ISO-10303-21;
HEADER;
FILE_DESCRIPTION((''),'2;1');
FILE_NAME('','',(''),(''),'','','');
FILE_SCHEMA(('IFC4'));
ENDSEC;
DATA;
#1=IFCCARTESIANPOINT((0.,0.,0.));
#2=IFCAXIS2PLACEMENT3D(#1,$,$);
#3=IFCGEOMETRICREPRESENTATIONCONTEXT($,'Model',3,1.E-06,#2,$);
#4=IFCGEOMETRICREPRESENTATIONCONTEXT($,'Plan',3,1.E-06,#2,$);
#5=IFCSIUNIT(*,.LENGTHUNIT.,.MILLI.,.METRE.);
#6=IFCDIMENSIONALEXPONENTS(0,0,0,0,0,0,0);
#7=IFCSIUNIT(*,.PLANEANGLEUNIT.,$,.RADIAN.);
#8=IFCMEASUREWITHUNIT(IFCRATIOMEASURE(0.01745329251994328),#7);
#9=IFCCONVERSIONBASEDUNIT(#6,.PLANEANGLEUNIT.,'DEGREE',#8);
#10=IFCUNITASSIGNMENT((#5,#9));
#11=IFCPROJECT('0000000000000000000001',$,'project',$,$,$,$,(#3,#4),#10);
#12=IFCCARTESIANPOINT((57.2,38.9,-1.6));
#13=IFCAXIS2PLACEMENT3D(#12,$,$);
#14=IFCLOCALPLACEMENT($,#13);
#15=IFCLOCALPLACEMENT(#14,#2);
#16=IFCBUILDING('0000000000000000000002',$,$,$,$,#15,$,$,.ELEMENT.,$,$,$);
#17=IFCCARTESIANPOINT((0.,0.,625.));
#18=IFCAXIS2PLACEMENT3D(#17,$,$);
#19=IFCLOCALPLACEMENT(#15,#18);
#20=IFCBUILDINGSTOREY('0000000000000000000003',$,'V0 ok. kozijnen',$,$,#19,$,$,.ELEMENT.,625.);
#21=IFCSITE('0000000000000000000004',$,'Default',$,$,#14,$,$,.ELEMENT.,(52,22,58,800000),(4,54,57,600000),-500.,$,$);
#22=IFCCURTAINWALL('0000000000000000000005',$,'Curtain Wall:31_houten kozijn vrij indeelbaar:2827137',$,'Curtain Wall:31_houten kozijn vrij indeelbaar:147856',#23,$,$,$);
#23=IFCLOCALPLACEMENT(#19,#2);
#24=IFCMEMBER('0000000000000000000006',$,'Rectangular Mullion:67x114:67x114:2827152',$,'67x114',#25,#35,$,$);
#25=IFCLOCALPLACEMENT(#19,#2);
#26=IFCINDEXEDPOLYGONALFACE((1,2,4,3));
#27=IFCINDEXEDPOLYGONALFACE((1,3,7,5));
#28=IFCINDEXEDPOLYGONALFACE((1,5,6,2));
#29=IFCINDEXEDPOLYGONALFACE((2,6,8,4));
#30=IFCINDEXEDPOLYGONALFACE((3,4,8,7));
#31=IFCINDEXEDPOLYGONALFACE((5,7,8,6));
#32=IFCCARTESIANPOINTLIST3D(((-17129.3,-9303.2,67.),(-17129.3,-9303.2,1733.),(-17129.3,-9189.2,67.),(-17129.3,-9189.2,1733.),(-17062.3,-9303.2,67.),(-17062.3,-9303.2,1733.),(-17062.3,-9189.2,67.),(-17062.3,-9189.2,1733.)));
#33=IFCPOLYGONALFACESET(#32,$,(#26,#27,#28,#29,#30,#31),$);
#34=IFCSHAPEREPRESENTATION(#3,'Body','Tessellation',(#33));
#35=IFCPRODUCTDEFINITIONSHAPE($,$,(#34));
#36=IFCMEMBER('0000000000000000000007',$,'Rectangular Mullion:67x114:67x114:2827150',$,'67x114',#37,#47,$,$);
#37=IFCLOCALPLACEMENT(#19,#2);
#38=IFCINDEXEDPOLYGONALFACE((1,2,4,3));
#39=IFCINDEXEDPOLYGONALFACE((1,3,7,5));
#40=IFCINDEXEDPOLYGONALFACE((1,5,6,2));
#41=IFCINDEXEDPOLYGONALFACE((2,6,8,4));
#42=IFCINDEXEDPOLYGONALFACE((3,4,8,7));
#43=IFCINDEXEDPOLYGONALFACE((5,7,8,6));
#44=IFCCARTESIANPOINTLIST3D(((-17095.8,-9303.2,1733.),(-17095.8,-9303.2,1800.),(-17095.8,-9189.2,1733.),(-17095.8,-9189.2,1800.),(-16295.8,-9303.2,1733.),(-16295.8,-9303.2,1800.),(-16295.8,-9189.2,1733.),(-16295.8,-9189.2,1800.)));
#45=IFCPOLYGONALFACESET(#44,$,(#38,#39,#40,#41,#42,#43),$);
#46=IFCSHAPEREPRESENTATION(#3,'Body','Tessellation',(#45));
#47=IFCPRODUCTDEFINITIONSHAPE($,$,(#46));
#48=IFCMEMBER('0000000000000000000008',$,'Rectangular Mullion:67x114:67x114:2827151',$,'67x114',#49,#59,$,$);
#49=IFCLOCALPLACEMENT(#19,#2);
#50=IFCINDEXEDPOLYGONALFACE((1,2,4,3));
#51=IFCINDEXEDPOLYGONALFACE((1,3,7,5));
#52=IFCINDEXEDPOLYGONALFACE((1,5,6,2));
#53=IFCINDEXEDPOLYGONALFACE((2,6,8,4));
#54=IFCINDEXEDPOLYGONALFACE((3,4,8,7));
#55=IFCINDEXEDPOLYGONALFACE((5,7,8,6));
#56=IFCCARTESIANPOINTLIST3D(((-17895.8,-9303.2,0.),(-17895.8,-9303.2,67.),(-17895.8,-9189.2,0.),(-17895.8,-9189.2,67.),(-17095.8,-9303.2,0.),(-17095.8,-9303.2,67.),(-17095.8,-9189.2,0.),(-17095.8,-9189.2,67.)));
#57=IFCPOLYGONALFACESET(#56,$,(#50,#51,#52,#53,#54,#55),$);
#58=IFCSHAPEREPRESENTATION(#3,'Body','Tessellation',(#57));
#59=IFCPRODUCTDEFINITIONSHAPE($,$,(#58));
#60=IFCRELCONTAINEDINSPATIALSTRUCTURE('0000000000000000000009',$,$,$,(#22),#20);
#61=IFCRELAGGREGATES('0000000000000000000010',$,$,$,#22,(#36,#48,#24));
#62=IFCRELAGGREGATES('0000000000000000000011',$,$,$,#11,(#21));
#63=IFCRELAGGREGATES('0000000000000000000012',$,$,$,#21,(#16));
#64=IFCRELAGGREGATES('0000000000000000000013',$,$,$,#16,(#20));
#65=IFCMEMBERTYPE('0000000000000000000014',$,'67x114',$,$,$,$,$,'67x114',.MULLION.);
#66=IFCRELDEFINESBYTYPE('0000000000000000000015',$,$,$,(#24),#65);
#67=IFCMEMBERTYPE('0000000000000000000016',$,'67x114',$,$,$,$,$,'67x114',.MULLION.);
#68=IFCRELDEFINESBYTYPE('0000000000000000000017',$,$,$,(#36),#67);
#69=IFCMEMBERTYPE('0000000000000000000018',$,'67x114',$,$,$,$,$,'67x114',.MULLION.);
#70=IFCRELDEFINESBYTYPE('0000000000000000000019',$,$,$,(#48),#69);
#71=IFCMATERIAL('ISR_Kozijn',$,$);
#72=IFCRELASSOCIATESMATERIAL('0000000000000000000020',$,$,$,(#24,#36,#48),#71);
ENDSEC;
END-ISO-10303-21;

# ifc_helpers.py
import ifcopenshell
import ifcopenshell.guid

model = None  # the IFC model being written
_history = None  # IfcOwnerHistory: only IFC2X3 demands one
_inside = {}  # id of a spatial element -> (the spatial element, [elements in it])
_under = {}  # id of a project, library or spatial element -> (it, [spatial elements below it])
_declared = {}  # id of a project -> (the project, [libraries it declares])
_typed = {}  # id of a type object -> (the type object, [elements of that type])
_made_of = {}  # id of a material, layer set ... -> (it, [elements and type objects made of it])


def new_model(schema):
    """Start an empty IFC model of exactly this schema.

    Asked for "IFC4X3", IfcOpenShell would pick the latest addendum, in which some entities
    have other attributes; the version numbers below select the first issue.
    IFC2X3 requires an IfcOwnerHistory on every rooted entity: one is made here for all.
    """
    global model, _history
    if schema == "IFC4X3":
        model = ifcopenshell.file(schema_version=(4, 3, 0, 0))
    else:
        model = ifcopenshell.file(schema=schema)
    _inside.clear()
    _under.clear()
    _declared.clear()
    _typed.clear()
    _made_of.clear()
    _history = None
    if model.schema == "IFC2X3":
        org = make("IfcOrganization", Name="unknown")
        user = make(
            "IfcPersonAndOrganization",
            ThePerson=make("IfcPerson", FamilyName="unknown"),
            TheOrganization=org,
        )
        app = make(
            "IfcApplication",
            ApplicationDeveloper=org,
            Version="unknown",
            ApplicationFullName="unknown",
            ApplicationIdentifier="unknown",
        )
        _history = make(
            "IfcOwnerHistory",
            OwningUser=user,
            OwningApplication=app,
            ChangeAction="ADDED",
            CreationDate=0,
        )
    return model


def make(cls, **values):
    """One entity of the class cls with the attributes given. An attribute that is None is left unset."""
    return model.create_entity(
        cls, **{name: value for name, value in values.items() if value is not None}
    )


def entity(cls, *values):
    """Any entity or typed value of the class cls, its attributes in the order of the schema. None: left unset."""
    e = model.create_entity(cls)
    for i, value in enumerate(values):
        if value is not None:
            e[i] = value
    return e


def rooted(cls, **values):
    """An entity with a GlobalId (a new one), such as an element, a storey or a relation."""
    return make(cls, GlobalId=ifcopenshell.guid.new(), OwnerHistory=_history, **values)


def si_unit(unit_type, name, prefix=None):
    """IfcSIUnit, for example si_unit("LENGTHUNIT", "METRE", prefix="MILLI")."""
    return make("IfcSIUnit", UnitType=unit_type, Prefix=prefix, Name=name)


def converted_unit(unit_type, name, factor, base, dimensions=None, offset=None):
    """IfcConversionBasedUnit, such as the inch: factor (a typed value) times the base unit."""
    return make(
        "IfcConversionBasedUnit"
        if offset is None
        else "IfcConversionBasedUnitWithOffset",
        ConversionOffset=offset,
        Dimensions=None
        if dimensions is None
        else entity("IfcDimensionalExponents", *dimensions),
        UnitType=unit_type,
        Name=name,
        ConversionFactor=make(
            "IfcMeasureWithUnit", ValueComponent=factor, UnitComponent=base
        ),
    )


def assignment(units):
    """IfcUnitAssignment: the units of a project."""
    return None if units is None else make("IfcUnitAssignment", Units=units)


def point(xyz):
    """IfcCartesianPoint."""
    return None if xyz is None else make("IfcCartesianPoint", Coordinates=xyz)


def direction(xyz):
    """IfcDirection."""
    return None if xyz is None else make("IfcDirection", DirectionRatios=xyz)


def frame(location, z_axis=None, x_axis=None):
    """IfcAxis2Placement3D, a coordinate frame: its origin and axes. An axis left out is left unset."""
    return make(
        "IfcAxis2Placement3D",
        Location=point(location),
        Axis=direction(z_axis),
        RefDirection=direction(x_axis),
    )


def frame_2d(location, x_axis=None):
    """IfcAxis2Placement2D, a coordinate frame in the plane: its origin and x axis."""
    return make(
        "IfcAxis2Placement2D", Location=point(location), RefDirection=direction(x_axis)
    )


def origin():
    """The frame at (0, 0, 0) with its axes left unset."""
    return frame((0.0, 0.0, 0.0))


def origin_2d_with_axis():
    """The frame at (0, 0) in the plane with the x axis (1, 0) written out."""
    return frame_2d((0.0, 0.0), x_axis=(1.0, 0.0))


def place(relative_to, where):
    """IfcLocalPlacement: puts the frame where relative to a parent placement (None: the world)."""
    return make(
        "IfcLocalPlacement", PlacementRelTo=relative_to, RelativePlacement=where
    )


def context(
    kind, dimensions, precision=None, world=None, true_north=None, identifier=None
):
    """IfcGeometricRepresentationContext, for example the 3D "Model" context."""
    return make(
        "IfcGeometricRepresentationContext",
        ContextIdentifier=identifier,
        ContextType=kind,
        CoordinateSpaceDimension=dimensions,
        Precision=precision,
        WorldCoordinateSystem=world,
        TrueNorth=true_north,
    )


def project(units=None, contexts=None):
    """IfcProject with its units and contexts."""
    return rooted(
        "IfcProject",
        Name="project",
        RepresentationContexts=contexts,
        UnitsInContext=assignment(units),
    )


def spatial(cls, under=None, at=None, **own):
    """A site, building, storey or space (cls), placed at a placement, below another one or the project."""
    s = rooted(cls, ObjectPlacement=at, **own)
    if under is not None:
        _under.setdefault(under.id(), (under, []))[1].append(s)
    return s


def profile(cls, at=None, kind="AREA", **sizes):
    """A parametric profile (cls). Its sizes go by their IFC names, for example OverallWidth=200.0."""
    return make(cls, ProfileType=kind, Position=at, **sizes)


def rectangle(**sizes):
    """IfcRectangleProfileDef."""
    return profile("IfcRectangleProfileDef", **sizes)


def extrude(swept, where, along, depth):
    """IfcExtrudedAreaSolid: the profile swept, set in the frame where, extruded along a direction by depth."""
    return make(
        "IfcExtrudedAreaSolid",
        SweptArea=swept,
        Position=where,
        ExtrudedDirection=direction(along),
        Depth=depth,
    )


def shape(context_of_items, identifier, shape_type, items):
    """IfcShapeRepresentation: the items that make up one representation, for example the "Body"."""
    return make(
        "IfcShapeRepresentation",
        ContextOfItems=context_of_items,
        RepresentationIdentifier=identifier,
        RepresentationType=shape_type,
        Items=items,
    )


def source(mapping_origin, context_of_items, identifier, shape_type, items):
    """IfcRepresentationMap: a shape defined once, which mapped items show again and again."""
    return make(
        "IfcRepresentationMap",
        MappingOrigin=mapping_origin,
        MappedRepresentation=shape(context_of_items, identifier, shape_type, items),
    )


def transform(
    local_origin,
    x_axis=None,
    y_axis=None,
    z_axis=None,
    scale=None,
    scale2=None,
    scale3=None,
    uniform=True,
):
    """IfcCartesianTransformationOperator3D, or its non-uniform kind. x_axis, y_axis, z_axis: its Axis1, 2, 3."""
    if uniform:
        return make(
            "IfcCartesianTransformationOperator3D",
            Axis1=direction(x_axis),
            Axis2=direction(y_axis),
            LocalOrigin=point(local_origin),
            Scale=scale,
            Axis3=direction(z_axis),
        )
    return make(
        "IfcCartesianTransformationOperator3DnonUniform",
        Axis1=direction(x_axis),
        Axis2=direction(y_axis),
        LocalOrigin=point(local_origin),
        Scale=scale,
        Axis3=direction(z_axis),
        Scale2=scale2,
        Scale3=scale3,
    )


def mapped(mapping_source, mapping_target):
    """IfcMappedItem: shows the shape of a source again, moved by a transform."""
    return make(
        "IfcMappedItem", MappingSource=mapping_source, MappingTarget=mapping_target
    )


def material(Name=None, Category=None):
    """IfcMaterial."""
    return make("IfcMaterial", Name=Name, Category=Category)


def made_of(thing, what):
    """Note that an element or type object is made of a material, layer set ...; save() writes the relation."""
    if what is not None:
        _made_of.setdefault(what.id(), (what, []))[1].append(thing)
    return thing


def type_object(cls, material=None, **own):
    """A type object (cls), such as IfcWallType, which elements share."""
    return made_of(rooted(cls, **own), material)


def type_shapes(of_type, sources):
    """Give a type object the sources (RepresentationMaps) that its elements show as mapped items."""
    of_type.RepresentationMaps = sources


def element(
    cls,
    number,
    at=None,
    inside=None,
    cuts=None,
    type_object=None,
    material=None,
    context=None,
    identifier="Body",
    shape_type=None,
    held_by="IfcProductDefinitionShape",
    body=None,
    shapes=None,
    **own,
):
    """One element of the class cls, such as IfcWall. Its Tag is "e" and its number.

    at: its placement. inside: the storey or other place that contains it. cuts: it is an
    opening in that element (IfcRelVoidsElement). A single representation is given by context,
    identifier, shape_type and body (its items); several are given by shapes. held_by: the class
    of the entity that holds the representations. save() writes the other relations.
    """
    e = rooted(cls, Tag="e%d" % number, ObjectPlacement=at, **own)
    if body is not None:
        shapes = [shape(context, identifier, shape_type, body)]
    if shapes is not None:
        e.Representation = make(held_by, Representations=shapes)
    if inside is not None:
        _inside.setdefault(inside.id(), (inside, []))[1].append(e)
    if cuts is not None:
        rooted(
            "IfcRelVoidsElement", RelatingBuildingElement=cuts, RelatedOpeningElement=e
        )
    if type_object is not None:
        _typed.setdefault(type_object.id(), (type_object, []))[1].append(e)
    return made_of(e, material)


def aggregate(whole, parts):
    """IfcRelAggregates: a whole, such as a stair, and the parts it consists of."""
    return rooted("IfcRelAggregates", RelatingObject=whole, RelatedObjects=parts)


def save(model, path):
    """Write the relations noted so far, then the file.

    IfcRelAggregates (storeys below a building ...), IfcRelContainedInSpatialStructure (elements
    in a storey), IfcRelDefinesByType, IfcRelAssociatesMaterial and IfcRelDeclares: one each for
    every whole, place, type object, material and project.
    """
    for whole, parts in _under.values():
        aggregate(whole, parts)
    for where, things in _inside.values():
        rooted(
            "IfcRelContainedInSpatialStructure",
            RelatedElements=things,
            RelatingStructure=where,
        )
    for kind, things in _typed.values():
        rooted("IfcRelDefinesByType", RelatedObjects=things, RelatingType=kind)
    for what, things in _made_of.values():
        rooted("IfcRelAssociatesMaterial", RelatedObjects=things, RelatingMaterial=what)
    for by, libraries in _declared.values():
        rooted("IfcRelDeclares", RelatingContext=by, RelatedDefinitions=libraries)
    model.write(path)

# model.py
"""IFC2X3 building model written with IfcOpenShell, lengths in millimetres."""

from ifc_helpers import new_model, entity, si_unit, converted_unit, frame, origin, origin_2d_with_axis, place, context, project, spatial, rectangle, extrude, source, transform, mapped, material, type_object, type_shapes, element, aggregate, save


model = new_model("IFC2X3")

# Units and contexts
model_context = context("Model", 3, precision=1e-06, world=origin())
plan_context = context("Plan", 3, precision=1e-06, world=origin())
ifc_project = project(units=[si_unit("LENGTHUNIT", "METRE", prefix="MILLI"), converted_unit("PLANEANGLEUNIT", "DEGREE", entity("IfcRatioMeasure", 0.01745329251994328), si_unit("PLANEANGLEUNIT", "RADIAN"), dimensions=[0, 0, 0, 0, 0, 0, 0])], contexts=[model_context, plan_context])

# Site, building, storey
site_placement = place(None, frame((57.2, 38.9, -1.6)))
site = spatial("IfcSite", under=ifc_project, at=site_placement, Name="Default", CompositionType="ELEMENT", RefLatitude=(52, 22, 58, 800000), RefLongitude=(4, 54, 57, 600000), RefElevation=-500.0)
building_placement = place(site_placement, origin())
building = spatial("IfcBuilding", under=site, at=building_placement, CompositionType="ELEMENT")
storey_placement = place(building_placement, frame((0.0, 0.0, 625.0)))
storey = spatial("IfcBuildingStorey", under=building, at=storey_placement, Name="V0 ok. kozijnen", CompositionType="ELEMENT", Elevation=625.0)

# Curtain wall, members
ifc_material_1 = material(Name="ISR_Kozijn")
placement = place(building_placement, frame((0.0, 0.0, 2425.0)))
curtain_wall_1_placement = place(storey_placement, origin())
curtain_wall_1 = element("IfcCurtainWall", 1, at=curtain_wall_1_placement, inside=storey, Name="Curtain Wall:31_houten kozijn vrij indeelbaar:2827137", ObjectType="Curtain Wall:31_houten kozijn vrij indeelbaar:147856")
member_type_1 = type_object("IfcMemberType", Name="67x114", ElementType="67x114", PredefinedType="MULLION")
shared_shape_1 = source(origin(), model_context, "Body", "SweptSolid", [
    extrude(rectangle(XDim=67.0, YDim=114.0, at=origin_2d_with_axis()), frame((0.0, -57.0, -1666.0), z_axis=(0.0, 0.0, 1.0), x_axis=(-1.0, 0.0, 0.0)), (0.0, 0.0, 1.0), 1666.0),
])
type_shapes(member_type_1, [shared_shape_1])
member_1_placement = place(storey_placement, frame((-17095.8, -9189.2, 67.0), z_axis=(0.0, 0.0, -1.0), x_axis=(-1.0, 0.0, 0.0)))
member_1 = element("IfcMember", 2, at=member_1_placement, type_object=member_type_1, material=ifc_material_1, Name="Rectangular Mullion:67x114:67x114:2827152", ObjectType="67x114", context=model_context, shape_type="MappedRepresentation", body=[
    mapped(shared_shape_1, transform((0.0, 0.0, 0.0), scale=1.0)),
])
member_type_2 = type_object("IfcMemberType", Name="67x114", ElementType="67x114", PredefinedType="MULLION")
shared_shape_2 = source(origin(), model_context, "Body", "SweptSolid", [
    extrude(rectangle(XDim=67.0, YDim=114.0, at=origin_2d_with_axis()), frame((-33.5, -57.0, -800.0), z_axis=(0.0, 0.0, 1.0), x_axis=(-1.0, 0.0, 0.0)), (0.0, 0.0, 1.0), 800.0),
])
type_shapes(member_type_2, [shared_shape_2])
member_2_placement = place(placement, frame((-17095.8, -9189.2, 0.0), z_axis=(-1.0, 0.0, 0.0), x_axis=(0.0, 0.0, 1.0)))
member_2 = element("IfcMember", 3, at=member_2_placement, type_object=member_type_2, material=ifc_material_1, Name="Rectangular Mullion:67x114:67x114:2827150", ObjectType="67x114", context=model_context, shape_type="MappedRepresentation", body=[
    mapped(shared_shape_2, transform((0.0, 0.0, 0.0), scale=1.0)),
])
member_type_3 = type_object("IfcMemberType", Name="67x114", ElementType="67x114", PredefinedType="MULLION")
shared_shape_3 = source(origin(), model_context, "Body", "SweptSolid", [
    extrude(rectangle(XDim=67.0, YDim=114.0, at=origin_2d_with_axis()), frame((-33.5, -57.0, -800.0), z_axis=(0.0, 0.0, 1.0), x_axis=(-1.0, 0.0, 0.0)), (0.0, 0.0, 1.0), 800.0),
])
type_shapes(member_type_3, [shared_shape_3])
member_3_placement = place(storey_placement, frame((-17095.8, -9189.2, 0.0), z_axis=(1.0, 0.0, 0.0), x_axis=(0.0, 0.0, -1.0)))
member_3 = element("IfcMember", 4, at=member_3_placement, type_object=member_type_3, material=ifc_material_1, Name="Rectangular Mullion:67x114:67x114:2827151", ObjectType="67x114", context=model_context, shape_type="MappedRepresentation", body=[
    mapped(shared_shape_3, transform((0.0, 0.0, 0.0), scale=1.0)),
])

aggregate(curtain_wall_1, [member_2, member_3, member_1])

save(model, "model.ifc")
